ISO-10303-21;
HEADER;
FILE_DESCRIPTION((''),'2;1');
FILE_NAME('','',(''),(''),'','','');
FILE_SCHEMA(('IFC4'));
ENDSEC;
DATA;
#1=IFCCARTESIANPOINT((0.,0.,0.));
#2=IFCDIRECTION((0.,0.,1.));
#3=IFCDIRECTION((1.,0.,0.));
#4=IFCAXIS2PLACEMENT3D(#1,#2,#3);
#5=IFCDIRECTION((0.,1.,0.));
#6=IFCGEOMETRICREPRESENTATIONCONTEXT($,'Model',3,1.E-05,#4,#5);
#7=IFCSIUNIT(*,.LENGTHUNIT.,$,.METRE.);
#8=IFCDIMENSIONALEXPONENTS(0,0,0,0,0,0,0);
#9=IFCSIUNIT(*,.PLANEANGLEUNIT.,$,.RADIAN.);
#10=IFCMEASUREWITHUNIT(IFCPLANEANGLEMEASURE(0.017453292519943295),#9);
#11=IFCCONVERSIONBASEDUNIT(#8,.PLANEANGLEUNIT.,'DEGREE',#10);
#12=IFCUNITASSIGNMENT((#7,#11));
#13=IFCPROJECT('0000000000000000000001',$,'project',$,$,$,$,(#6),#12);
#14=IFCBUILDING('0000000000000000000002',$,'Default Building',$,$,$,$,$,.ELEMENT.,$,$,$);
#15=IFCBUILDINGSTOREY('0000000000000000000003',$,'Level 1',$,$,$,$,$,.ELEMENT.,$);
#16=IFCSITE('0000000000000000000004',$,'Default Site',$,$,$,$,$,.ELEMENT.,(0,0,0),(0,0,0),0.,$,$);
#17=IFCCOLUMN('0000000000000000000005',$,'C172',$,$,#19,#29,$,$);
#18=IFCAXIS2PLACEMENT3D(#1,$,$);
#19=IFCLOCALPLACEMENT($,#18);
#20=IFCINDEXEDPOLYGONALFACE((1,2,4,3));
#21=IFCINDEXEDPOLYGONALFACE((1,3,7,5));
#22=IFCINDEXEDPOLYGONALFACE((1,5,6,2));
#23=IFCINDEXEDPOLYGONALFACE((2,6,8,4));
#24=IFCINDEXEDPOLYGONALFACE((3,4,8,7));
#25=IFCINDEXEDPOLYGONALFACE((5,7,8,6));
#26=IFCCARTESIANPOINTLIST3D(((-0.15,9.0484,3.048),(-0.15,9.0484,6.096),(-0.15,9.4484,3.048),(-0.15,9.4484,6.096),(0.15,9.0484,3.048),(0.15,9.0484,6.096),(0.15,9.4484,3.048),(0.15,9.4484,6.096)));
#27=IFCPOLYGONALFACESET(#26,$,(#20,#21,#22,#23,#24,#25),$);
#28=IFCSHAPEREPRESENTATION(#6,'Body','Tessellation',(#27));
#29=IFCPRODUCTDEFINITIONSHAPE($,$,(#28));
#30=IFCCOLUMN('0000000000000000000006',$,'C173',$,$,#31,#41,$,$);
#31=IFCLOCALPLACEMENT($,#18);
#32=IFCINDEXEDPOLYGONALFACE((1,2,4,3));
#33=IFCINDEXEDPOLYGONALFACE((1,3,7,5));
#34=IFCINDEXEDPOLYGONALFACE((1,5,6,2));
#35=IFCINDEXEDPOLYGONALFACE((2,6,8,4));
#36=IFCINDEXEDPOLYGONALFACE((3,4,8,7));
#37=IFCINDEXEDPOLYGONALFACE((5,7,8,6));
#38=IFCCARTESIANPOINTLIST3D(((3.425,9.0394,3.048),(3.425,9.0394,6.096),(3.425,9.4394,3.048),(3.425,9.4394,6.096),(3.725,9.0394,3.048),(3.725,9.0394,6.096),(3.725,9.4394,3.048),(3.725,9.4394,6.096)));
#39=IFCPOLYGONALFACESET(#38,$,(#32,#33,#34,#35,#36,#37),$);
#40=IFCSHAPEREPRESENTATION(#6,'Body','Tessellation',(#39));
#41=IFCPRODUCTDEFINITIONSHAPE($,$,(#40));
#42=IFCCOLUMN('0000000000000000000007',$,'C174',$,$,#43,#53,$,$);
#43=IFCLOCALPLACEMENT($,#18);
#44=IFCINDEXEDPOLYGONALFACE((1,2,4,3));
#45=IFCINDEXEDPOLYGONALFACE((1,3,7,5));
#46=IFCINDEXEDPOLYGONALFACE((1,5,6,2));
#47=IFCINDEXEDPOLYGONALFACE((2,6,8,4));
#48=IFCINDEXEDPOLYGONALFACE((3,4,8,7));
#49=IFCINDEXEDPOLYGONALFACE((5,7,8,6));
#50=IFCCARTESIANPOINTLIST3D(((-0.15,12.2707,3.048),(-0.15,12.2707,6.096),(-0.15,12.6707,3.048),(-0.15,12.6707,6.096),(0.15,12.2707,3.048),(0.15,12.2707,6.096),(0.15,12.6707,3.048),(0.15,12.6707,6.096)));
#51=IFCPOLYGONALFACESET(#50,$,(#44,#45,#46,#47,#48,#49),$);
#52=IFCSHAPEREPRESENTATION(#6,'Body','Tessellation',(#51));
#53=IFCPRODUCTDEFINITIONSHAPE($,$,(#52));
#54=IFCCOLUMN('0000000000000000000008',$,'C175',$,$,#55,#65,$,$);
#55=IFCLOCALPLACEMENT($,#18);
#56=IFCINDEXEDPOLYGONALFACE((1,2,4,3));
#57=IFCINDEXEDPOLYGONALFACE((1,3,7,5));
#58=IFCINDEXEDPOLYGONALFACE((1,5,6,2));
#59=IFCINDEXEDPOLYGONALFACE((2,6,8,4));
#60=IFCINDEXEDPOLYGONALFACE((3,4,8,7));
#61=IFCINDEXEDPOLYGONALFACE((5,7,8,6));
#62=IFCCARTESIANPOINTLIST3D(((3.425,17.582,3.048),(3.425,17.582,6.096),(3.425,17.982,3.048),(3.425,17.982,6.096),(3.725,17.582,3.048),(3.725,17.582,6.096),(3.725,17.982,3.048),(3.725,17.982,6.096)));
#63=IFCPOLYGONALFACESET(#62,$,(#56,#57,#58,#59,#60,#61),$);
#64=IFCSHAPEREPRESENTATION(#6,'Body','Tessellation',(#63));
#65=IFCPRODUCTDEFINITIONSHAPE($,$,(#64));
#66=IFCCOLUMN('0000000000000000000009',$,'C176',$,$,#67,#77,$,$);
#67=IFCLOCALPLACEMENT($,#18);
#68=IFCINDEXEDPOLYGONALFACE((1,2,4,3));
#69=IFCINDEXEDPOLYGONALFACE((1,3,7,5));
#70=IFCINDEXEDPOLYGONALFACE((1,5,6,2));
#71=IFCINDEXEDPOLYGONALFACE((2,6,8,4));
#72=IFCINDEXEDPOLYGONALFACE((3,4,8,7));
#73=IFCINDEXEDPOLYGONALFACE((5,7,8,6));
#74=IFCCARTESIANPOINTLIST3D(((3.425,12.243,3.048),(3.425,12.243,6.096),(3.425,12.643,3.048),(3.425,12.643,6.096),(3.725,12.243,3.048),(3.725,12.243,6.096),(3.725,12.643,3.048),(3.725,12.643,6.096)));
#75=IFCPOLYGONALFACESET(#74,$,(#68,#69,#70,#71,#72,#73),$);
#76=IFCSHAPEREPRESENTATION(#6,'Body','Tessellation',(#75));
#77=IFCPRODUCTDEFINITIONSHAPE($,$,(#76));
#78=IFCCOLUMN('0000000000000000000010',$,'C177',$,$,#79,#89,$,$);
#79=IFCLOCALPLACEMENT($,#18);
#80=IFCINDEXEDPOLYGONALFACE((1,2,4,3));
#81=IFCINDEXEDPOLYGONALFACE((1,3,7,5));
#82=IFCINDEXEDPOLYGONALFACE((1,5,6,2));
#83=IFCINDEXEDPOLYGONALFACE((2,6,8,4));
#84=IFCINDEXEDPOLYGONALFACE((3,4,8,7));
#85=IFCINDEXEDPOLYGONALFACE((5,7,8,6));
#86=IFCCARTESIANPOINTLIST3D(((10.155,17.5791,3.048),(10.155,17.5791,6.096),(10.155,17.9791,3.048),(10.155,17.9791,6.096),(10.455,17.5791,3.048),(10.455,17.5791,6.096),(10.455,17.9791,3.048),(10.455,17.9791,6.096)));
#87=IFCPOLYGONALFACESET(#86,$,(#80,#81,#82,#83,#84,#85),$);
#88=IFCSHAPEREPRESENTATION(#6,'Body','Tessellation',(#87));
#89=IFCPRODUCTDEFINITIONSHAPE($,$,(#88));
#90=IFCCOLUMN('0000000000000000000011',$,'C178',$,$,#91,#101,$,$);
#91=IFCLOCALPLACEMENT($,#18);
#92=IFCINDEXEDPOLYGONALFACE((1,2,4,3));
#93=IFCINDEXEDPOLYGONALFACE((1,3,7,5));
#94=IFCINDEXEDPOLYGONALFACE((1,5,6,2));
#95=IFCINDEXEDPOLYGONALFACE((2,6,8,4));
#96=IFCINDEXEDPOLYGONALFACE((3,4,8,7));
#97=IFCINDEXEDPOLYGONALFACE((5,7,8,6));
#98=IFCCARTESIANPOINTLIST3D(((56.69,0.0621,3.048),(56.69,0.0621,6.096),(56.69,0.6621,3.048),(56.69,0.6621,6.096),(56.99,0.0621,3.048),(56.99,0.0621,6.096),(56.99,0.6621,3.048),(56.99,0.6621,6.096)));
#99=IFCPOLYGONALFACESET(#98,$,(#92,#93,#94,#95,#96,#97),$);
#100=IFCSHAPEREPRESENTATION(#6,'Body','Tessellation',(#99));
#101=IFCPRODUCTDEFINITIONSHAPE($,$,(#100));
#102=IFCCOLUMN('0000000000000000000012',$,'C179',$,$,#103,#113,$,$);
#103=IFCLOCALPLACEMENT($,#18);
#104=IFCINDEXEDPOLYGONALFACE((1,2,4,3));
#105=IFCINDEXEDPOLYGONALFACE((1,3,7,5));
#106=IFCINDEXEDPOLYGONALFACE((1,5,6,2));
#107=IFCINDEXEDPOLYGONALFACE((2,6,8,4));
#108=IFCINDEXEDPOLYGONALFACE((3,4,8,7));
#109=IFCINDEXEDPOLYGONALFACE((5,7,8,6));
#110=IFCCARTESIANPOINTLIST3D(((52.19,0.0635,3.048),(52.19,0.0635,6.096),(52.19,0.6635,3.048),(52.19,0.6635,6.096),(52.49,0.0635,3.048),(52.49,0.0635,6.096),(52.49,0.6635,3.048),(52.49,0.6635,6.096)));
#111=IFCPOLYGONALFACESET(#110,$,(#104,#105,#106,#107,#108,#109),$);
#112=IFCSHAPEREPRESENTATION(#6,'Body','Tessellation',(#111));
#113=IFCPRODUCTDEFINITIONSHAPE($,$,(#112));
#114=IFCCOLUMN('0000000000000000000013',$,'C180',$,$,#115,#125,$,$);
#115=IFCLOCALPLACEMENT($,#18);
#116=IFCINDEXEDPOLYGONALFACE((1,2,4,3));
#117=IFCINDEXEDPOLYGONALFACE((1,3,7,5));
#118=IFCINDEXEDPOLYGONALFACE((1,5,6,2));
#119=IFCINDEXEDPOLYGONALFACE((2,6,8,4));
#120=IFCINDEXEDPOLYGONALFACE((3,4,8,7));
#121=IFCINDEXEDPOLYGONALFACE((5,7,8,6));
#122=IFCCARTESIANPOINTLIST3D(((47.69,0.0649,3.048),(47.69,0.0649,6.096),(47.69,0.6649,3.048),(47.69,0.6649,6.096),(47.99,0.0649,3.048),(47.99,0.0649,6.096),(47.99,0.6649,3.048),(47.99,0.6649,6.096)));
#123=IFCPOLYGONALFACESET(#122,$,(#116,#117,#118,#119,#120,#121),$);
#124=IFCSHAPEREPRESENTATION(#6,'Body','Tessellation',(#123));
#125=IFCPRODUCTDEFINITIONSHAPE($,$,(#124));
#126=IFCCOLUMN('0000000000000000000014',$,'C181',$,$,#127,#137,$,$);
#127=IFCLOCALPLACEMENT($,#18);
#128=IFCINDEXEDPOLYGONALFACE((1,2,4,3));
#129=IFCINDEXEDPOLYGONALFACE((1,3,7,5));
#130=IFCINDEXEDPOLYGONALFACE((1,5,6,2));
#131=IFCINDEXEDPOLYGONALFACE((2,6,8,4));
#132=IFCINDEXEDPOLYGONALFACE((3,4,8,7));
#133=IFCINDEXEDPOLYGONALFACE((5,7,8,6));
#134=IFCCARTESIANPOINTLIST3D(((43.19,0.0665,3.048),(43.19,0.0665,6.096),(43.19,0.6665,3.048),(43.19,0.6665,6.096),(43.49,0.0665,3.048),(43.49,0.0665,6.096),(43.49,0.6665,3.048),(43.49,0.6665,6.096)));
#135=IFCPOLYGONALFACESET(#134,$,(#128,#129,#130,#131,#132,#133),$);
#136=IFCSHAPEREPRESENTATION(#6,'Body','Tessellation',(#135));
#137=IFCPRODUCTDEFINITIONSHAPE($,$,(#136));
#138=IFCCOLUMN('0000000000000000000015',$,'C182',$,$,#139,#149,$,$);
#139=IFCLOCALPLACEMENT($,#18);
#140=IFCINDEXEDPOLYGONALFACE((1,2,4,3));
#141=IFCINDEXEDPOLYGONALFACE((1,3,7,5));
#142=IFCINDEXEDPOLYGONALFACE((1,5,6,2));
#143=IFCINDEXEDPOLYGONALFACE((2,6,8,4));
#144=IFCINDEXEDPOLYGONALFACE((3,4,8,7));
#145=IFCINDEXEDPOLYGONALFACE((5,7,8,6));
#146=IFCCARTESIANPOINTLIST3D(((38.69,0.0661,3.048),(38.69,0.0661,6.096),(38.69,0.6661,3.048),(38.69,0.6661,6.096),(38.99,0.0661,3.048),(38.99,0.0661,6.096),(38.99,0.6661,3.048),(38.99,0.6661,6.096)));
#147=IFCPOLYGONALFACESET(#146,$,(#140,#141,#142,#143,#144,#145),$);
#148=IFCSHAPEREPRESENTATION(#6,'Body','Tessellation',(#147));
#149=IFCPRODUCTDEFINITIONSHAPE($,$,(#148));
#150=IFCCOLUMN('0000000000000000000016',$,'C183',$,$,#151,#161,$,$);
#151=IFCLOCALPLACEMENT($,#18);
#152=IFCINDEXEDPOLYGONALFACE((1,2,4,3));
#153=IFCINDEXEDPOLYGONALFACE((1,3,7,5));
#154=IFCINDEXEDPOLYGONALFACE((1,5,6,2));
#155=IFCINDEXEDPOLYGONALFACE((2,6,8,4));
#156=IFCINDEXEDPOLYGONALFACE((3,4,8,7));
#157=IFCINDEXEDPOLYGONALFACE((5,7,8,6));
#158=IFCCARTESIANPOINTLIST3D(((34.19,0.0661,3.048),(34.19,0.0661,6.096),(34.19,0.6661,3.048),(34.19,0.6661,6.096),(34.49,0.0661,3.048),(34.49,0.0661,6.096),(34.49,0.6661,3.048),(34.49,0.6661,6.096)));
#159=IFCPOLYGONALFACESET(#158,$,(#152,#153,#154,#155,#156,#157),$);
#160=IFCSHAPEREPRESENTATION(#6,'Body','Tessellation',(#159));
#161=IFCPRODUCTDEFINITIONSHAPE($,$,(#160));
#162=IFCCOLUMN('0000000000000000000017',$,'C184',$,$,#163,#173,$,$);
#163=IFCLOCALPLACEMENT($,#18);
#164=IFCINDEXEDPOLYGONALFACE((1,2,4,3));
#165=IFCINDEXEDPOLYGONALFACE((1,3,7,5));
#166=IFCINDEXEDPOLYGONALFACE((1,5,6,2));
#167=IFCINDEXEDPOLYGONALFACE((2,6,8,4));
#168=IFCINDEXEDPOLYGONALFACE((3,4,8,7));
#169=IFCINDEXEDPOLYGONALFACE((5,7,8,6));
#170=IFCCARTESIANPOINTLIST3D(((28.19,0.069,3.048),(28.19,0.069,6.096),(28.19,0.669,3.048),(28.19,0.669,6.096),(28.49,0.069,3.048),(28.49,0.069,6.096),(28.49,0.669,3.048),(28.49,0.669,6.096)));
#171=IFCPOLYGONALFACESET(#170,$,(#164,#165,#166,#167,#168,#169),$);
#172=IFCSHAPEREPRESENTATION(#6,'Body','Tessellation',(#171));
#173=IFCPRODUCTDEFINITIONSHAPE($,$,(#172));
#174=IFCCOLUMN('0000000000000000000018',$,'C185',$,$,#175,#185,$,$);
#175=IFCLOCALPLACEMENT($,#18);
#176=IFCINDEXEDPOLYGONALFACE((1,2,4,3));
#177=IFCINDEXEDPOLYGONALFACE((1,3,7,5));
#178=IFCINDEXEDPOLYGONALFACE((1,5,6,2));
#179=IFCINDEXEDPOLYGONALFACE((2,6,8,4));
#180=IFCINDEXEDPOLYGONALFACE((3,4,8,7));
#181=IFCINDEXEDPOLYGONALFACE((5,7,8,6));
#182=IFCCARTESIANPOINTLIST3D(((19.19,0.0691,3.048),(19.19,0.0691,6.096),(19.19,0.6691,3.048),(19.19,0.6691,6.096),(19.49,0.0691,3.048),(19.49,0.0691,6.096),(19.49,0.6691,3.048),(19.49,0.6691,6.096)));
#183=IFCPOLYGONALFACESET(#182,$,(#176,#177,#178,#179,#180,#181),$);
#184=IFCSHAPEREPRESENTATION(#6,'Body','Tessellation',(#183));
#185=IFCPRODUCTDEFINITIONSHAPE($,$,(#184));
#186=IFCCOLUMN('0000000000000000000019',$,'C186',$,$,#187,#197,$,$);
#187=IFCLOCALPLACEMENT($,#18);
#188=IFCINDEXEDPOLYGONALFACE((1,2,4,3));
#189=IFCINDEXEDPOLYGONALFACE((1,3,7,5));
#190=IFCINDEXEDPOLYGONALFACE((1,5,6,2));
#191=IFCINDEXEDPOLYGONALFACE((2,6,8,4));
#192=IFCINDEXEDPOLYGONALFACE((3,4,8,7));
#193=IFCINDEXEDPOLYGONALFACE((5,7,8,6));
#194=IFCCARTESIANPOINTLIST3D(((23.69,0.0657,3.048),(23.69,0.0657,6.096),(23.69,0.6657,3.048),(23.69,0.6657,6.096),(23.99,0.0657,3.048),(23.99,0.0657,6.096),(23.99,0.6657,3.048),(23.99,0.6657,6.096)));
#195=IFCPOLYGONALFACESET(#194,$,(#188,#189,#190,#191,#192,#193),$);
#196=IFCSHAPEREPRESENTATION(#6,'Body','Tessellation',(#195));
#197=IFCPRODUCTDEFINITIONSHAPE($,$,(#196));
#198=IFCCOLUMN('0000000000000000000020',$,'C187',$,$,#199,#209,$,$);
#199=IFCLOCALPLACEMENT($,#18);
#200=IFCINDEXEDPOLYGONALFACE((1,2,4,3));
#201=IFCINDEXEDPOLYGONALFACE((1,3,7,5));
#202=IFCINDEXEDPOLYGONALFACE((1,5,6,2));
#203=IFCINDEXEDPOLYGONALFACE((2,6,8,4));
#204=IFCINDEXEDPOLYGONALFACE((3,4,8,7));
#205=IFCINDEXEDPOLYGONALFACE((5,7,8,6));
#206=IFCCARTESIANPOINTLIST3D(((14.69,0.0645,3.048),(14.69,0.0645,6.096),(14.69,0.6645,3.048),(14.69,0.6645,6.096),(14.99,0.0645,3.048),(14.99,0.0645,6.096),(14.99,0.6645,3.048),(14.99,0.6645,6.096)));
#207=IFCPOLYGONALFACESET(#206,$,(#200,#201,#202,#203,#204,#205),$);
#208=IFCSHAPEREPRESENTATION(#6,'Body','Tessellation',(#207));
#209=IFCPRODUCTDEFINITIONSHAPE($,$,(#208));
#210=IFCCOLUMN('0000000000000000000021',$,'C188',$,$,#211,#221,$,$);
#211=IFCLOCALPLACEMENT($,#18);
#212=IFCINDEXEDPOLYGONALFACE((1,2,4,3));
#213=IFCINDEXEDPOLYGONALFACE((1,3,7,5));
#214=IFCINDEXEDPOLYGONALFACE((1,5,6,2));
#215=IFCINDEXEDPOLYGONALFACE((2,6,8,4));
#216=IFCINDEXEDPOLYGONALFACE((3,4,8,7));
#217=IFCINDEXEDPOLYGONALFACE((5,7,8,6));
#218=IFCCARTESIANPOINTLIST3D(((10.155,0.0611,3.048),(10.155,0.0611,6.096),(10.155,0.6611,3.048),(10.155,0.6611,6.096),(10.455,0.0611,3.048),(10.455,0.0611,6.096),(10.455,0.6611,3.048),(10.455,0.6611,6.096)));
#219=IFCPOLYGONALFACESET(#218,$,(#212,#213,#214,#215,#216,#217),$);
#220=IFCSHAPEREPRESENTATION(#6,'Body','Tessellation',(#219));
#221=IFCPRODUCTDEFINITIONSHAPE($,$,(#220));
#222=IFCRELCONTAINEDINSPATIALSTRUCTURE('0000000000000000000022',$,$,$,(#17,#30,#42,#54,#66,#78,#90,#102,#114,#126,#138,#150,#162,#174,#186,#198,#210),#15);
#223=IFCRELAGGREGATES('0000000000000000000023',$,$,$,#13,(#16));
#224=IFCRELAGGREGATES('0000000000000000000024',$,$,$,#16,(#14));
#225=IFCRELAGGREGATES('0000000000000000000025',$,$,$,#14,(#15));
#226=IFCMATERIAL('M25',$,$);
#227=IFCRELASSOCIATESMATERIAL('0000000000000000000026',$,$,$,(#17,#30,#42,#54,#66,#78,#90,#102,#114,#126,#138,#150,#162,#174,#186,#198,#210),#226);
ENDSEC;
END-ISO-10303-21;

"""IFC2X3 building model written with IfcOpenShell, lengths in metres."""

from ifc_helpers import new_model, entity, si_unit, converted_unit, direction, frame, frame_2d, origin_with_axes, place, context, project, spatial, rectangle, extrude, material, element, save


model = new_model("IFC2X3")

# Units and contexts
model_context = context("Model", 3, precision=1e-05, world=origin_with_axes(), true_north=direction((0.0, 1.0, 0.0)))
ifc_project = project(units=[si_unit("LENGTHUNIT", "METRE"), converted_unit("PLANEANGLEUNIT", "DEGREE", entity("IfcPlaneAngleMeasure", 0.017453292519943295), si_unit("PLANEANGLEUNIT", "RADIAN"), dimensions=[0, 0, 0, 0, 0, 0, 0])], contexts=[model_context])

# Site, building, storey
site = spatial("IfcSite", under=ifc_project, Name="Default Site", CompositionType="ELEMENT", RefLatitude=(0, 0, 0), RefLongitude=(0, 0, 0), RefElevation=0.0)
building = spatial("IfcBuilding", under=site, Name="Default Building", CompositionType="ELEMENT")
storey = spatial("IfcBuildingStorey", under=building, Name="Level 1", CompositionType="ELEMENT")

# Columns
ifc_material = material(Name="M25")
placement = place(None, origin_with_axes())
element("IfcColumn", 1, at=placement, inside=storey, material=ifc_material, Name="C172", context=model_context, shape_type="SweptSolid", body=[
    extrude(rectangle(XDim=0.3, YDim=0.4, at=frame_2d((0.0, 0.0), x_axis=(1.0, 0.0, 0.0))), frame((0.0, 9.2484, 3.048), z_axis=(0.0, 0.0, 1.0), x_axis=(1.0, 0.0, 0.0)), (0.0, 0.0, 1.0), 3.048),
])
element("IfcColumn", 2, at=placement, inside=storey, material=ifc_material, Name="C173", context=model_context, shape_type="SweptSolid", body=[
    extrude(rectangle(XDim=0.3, YDim=0.4, at=frame_2d((0.0, 0.0), x_axis=(1.0, 0.0, 0.0))), frame((3.575, 9.2394, 3.048), z_axis=(0.0, 0.0, 1.0), x_axis=(1.0, 0.0, 0.0)), (0.0, 0.0, 1.0), 3.048),
])
element("IfcColumn", 3, at=placement, inside=storey, material=ifc_material, Name="C174", context=model_context, shape_type="SweptSolid", body=[
    extrude(rectangle(XDim=0.3, YDim=0.4, at=frame_2d((0.0, 0.0), x_axis=(1.0, 0.0, 0.0))), frame((0.0, 12.4707, 3.048), z_axis=(0.0, 0.0, 1.0), x_axis=(1.0, 0.0, 0.0)), (0.0, 0.0, 1.0), 3.048),
])
element("IfcColumn", 4, at=placement, inside=storey, material=ifc_material, Name="C175", context=model_context, shape_type="SweptSolid", body=[
    extrude(rectangle(XDim=0.3, YDim=0.4, at=frame_2d((0.0, 0.0), x_axis=(1.0, 0.0, 0.0))), frame((3.575, 17.782, 3.048), z_axis=(0.0, 0.0, 1.0), x_axis=(1.0, 0.0, 0.0)), (0.0, 0.0, 1.0), 3.048),
])
element("IfcColumn", 5, at=placement, inside=storey, material=ifc_material, Name="C176", context=model_context, shape_type="SweptSolid", body=[
    extrude(rectangle(XDim=0.3, YDim=0.4, at=frame_2d((0.0, 0.0), x_axis=(1.0, 0.0, 0.0))), frame((3.575, 12.443, 3.048), z_axis=(0.0, 0.0, 1.0), x_axis=(1.0, 0.0, 0.0)), (0.0, 0.0, 1.0), 3.048),
])
element("IfcColumn", 6, at=placement, inside=storey, material=ifc_material, Name="C177", context=model_context, shape_type="SweptSolid", body=[
    extrude(rectangle(XDim=0.3, YDim=0.4, at=frame_2d((0.0, 0.0), x_axis=(1.0, 0.0, 0.0))), frame((10.305, 17.7791, 3.048), z_axis=(0.0, 0.0, 1.0), x_axis=(1.0, 0.0, 0.0)), (0.0, 0.0, 1.0), 3.048),
])
element("IfcColumn", 7, at=placement, inside=storey, material=ifc_material, Name="C178", context=model_context, shape_type="SweptSolid", body=[
    extrude(rectangle(XDim=0.3, YDim=0.6, at=frame_2d((0.0, 0.0), x_axis=(1.0, 0.0, 0.0))), frame((56.84, 0.3621, 3.048), z_axis=(0.0, 0.0, 1.0), x_axis=(1.0, 0.0, 0.0)), (0.0, 0.0, 1.0), 3.048),
])
element("IfcColumn", 8, at=placement, inside=storey, material=ifc_material, Name="C179", context=model_context, shape_type="SweptSolid", body=[
    extrude(rectangle(XDim=0.3, YDim=0.6, at=frame_2d((0.0, 0.0), x_axis=(1.0, 0.0, 0.0))), frame((52.34, 0.3635, 3.048), z_axis=(0.0, 0.0, 1.0), x_axis=(1.0, 0.0, 0.0)), (0.0, 0.0, 1.0), 3.048),
])
element("IfcColumn", 9, at=placement, inside=storey, material=ifc_material, Name="C180", context=model_context, shape_type="SweptSolid", body=[
    extrude(rectangle(XDim=0.3, YDim=0.6, at=frame_2d((0.0, 0.0), x_axis=(1.0, 0.0, 0.0))), frame((47.84, 0.3649, 3.048), z_axis=(0.0, 0.0, 1.0), x_axis=(1.0, 0.0, 0.0)), (0.0, 0.0, 1.0), 3.048),
])
element("IfcColumn", 10, at=placement, inside=storey, material=ifc_material, Name="C181", context=model_context, shape_type="SweptSolid", body=[
    extrude(rectangle(XDim=0.3, YDim=0.6, at=frame_2d((0.0, 0.0), x_axis=(1.0, 0.0, 0.0))), frame((43.34, 0.3665, 3.048), z_axis=(0.0, 0.0, 1.0), x_axis=(1.0, 0.0, 0.0)), (0.0, 0.0, 1.0), 3.048),
])
element("IfcColumn", 11, at=placement, inside=storey, material=ifc_material, Name="C182", context=model_context, shape_type="SweptSolid", body=[
    extrude(rectangle(XDim=0.3, YDim=0.6, at=frame_2d((0.0, 0.0), x_axis=(1.0, 0.0, 0.0))), frame((38.84, 0.3661, 3.048), z_axis=(0.0, 0.0, 1.0), x_axis=(1.0, 0.0, 0.0)), (0.0, 0.0, 1.0), 3.048),
])
element("IfcColumn", 12, at=placement, inside=storey, material=ifc_material, Name="C183", context=model_context, shape_type="SweptSolid", body=[
    extrude(rectangle(XDim=0.3, YDim=0.6, at=frame_2d((0.0, 0.0), x_axis=(1.0, 0.0, 0.0))), frame((34.34, 0.3661, 3.048), z_axis=(0.0, 0.0, 1.0), x_axis=(1.0, 0.0, 0.0)), (0.0, 0.0, 1.0), 3.048),
])
element("IfcColumn", 13, at=placement, inside=storey, material=ifc_material, Name="C184", context=model_context, shape_type="SweptSolid", body=[
    extrude(rectangle(XDim=0.3, YDim=0.6, at=frame_2d((0.0, 0.0), x_axis=(1.0, 0.0, 0.0))), frame((28.34, 0.369, 3.048), z_axis=(0.0, 0.0, 1.0), x_axis=(1.0, 0.0, 0.0)), (0.0, 0.0, 1.0), 3.048),
])
element("IfcColumn", 14, at=placement, inside=storey, material=ifc_material, Name="C185", context=model_context, shape_type="SweptSolid", body=[
    extrude(rectangle(XDim=0.3, YDim=0.6, at=frame_2d((0.0, 0.0), x_axis=(1.0, 0.0, 0.0))), frame((19.34, 0.3691, 3.048), z_axis=(0.0, 0.0, 1.0), x_axis=(1.0, 0.0, 0.0)), (0.0, 0.0, 1.0), 3.048),
])
element("IfcColumn", 15, at=placement, inside=storey, material=ifc_material, Name="C186", context=model_context, shape_type="SweptSolid", body=[
    extrude(rectangle(XDim=0.3, YDim=0.6, at=frame_2d((0.0, 0.0), x_axis=(1.0, 0.0, 0.0))), frame((23.84, 0.3657, 3.048), z_axis=(0.0, 0.0, 1.0), x_axis=(1.0, 0.0, 0.0)), (0.0, 0.0, 1.0), 3.048),
])
element("IfcColumn", 16, at=placement, inside=storey, material=ifc_material, Name="C187", context=model_context, shape_type="SweptSolid", body=[
    extrude(rectangle(XDim=0.3, YDim=0.6, at=frame_2d((0.0, 0.0), x_axis=(1.0, 0.0, 0.0))), frame((14.84, 0.3645, 3.048), z_axis=(0.0, 0.0, 1.0), x_axis=(1.0, 0.0, 0.0)), (0.0, 0.0, 1.0), 3.048),
])
element("IfcColumn", 17, at=placement, inside=storey, material=ifc_material, Name="C188", context=model_context, shape_type="SweptSolid", body=[
    extrude(rectangle(XDim=0.3, YDim=0.6, at=frame_2d((0.0, 0.0), x_axis=(1.0, 0.0, 0.0))), frame((10.305, 0.3611, 3.048), z_axis=(0.0, 0.0, 1.0), x_axis=(1.0, 0.0, 0.0)), (0.0, 0.0, 1.0), 3.048),
])

save(model, "model.ifc")
